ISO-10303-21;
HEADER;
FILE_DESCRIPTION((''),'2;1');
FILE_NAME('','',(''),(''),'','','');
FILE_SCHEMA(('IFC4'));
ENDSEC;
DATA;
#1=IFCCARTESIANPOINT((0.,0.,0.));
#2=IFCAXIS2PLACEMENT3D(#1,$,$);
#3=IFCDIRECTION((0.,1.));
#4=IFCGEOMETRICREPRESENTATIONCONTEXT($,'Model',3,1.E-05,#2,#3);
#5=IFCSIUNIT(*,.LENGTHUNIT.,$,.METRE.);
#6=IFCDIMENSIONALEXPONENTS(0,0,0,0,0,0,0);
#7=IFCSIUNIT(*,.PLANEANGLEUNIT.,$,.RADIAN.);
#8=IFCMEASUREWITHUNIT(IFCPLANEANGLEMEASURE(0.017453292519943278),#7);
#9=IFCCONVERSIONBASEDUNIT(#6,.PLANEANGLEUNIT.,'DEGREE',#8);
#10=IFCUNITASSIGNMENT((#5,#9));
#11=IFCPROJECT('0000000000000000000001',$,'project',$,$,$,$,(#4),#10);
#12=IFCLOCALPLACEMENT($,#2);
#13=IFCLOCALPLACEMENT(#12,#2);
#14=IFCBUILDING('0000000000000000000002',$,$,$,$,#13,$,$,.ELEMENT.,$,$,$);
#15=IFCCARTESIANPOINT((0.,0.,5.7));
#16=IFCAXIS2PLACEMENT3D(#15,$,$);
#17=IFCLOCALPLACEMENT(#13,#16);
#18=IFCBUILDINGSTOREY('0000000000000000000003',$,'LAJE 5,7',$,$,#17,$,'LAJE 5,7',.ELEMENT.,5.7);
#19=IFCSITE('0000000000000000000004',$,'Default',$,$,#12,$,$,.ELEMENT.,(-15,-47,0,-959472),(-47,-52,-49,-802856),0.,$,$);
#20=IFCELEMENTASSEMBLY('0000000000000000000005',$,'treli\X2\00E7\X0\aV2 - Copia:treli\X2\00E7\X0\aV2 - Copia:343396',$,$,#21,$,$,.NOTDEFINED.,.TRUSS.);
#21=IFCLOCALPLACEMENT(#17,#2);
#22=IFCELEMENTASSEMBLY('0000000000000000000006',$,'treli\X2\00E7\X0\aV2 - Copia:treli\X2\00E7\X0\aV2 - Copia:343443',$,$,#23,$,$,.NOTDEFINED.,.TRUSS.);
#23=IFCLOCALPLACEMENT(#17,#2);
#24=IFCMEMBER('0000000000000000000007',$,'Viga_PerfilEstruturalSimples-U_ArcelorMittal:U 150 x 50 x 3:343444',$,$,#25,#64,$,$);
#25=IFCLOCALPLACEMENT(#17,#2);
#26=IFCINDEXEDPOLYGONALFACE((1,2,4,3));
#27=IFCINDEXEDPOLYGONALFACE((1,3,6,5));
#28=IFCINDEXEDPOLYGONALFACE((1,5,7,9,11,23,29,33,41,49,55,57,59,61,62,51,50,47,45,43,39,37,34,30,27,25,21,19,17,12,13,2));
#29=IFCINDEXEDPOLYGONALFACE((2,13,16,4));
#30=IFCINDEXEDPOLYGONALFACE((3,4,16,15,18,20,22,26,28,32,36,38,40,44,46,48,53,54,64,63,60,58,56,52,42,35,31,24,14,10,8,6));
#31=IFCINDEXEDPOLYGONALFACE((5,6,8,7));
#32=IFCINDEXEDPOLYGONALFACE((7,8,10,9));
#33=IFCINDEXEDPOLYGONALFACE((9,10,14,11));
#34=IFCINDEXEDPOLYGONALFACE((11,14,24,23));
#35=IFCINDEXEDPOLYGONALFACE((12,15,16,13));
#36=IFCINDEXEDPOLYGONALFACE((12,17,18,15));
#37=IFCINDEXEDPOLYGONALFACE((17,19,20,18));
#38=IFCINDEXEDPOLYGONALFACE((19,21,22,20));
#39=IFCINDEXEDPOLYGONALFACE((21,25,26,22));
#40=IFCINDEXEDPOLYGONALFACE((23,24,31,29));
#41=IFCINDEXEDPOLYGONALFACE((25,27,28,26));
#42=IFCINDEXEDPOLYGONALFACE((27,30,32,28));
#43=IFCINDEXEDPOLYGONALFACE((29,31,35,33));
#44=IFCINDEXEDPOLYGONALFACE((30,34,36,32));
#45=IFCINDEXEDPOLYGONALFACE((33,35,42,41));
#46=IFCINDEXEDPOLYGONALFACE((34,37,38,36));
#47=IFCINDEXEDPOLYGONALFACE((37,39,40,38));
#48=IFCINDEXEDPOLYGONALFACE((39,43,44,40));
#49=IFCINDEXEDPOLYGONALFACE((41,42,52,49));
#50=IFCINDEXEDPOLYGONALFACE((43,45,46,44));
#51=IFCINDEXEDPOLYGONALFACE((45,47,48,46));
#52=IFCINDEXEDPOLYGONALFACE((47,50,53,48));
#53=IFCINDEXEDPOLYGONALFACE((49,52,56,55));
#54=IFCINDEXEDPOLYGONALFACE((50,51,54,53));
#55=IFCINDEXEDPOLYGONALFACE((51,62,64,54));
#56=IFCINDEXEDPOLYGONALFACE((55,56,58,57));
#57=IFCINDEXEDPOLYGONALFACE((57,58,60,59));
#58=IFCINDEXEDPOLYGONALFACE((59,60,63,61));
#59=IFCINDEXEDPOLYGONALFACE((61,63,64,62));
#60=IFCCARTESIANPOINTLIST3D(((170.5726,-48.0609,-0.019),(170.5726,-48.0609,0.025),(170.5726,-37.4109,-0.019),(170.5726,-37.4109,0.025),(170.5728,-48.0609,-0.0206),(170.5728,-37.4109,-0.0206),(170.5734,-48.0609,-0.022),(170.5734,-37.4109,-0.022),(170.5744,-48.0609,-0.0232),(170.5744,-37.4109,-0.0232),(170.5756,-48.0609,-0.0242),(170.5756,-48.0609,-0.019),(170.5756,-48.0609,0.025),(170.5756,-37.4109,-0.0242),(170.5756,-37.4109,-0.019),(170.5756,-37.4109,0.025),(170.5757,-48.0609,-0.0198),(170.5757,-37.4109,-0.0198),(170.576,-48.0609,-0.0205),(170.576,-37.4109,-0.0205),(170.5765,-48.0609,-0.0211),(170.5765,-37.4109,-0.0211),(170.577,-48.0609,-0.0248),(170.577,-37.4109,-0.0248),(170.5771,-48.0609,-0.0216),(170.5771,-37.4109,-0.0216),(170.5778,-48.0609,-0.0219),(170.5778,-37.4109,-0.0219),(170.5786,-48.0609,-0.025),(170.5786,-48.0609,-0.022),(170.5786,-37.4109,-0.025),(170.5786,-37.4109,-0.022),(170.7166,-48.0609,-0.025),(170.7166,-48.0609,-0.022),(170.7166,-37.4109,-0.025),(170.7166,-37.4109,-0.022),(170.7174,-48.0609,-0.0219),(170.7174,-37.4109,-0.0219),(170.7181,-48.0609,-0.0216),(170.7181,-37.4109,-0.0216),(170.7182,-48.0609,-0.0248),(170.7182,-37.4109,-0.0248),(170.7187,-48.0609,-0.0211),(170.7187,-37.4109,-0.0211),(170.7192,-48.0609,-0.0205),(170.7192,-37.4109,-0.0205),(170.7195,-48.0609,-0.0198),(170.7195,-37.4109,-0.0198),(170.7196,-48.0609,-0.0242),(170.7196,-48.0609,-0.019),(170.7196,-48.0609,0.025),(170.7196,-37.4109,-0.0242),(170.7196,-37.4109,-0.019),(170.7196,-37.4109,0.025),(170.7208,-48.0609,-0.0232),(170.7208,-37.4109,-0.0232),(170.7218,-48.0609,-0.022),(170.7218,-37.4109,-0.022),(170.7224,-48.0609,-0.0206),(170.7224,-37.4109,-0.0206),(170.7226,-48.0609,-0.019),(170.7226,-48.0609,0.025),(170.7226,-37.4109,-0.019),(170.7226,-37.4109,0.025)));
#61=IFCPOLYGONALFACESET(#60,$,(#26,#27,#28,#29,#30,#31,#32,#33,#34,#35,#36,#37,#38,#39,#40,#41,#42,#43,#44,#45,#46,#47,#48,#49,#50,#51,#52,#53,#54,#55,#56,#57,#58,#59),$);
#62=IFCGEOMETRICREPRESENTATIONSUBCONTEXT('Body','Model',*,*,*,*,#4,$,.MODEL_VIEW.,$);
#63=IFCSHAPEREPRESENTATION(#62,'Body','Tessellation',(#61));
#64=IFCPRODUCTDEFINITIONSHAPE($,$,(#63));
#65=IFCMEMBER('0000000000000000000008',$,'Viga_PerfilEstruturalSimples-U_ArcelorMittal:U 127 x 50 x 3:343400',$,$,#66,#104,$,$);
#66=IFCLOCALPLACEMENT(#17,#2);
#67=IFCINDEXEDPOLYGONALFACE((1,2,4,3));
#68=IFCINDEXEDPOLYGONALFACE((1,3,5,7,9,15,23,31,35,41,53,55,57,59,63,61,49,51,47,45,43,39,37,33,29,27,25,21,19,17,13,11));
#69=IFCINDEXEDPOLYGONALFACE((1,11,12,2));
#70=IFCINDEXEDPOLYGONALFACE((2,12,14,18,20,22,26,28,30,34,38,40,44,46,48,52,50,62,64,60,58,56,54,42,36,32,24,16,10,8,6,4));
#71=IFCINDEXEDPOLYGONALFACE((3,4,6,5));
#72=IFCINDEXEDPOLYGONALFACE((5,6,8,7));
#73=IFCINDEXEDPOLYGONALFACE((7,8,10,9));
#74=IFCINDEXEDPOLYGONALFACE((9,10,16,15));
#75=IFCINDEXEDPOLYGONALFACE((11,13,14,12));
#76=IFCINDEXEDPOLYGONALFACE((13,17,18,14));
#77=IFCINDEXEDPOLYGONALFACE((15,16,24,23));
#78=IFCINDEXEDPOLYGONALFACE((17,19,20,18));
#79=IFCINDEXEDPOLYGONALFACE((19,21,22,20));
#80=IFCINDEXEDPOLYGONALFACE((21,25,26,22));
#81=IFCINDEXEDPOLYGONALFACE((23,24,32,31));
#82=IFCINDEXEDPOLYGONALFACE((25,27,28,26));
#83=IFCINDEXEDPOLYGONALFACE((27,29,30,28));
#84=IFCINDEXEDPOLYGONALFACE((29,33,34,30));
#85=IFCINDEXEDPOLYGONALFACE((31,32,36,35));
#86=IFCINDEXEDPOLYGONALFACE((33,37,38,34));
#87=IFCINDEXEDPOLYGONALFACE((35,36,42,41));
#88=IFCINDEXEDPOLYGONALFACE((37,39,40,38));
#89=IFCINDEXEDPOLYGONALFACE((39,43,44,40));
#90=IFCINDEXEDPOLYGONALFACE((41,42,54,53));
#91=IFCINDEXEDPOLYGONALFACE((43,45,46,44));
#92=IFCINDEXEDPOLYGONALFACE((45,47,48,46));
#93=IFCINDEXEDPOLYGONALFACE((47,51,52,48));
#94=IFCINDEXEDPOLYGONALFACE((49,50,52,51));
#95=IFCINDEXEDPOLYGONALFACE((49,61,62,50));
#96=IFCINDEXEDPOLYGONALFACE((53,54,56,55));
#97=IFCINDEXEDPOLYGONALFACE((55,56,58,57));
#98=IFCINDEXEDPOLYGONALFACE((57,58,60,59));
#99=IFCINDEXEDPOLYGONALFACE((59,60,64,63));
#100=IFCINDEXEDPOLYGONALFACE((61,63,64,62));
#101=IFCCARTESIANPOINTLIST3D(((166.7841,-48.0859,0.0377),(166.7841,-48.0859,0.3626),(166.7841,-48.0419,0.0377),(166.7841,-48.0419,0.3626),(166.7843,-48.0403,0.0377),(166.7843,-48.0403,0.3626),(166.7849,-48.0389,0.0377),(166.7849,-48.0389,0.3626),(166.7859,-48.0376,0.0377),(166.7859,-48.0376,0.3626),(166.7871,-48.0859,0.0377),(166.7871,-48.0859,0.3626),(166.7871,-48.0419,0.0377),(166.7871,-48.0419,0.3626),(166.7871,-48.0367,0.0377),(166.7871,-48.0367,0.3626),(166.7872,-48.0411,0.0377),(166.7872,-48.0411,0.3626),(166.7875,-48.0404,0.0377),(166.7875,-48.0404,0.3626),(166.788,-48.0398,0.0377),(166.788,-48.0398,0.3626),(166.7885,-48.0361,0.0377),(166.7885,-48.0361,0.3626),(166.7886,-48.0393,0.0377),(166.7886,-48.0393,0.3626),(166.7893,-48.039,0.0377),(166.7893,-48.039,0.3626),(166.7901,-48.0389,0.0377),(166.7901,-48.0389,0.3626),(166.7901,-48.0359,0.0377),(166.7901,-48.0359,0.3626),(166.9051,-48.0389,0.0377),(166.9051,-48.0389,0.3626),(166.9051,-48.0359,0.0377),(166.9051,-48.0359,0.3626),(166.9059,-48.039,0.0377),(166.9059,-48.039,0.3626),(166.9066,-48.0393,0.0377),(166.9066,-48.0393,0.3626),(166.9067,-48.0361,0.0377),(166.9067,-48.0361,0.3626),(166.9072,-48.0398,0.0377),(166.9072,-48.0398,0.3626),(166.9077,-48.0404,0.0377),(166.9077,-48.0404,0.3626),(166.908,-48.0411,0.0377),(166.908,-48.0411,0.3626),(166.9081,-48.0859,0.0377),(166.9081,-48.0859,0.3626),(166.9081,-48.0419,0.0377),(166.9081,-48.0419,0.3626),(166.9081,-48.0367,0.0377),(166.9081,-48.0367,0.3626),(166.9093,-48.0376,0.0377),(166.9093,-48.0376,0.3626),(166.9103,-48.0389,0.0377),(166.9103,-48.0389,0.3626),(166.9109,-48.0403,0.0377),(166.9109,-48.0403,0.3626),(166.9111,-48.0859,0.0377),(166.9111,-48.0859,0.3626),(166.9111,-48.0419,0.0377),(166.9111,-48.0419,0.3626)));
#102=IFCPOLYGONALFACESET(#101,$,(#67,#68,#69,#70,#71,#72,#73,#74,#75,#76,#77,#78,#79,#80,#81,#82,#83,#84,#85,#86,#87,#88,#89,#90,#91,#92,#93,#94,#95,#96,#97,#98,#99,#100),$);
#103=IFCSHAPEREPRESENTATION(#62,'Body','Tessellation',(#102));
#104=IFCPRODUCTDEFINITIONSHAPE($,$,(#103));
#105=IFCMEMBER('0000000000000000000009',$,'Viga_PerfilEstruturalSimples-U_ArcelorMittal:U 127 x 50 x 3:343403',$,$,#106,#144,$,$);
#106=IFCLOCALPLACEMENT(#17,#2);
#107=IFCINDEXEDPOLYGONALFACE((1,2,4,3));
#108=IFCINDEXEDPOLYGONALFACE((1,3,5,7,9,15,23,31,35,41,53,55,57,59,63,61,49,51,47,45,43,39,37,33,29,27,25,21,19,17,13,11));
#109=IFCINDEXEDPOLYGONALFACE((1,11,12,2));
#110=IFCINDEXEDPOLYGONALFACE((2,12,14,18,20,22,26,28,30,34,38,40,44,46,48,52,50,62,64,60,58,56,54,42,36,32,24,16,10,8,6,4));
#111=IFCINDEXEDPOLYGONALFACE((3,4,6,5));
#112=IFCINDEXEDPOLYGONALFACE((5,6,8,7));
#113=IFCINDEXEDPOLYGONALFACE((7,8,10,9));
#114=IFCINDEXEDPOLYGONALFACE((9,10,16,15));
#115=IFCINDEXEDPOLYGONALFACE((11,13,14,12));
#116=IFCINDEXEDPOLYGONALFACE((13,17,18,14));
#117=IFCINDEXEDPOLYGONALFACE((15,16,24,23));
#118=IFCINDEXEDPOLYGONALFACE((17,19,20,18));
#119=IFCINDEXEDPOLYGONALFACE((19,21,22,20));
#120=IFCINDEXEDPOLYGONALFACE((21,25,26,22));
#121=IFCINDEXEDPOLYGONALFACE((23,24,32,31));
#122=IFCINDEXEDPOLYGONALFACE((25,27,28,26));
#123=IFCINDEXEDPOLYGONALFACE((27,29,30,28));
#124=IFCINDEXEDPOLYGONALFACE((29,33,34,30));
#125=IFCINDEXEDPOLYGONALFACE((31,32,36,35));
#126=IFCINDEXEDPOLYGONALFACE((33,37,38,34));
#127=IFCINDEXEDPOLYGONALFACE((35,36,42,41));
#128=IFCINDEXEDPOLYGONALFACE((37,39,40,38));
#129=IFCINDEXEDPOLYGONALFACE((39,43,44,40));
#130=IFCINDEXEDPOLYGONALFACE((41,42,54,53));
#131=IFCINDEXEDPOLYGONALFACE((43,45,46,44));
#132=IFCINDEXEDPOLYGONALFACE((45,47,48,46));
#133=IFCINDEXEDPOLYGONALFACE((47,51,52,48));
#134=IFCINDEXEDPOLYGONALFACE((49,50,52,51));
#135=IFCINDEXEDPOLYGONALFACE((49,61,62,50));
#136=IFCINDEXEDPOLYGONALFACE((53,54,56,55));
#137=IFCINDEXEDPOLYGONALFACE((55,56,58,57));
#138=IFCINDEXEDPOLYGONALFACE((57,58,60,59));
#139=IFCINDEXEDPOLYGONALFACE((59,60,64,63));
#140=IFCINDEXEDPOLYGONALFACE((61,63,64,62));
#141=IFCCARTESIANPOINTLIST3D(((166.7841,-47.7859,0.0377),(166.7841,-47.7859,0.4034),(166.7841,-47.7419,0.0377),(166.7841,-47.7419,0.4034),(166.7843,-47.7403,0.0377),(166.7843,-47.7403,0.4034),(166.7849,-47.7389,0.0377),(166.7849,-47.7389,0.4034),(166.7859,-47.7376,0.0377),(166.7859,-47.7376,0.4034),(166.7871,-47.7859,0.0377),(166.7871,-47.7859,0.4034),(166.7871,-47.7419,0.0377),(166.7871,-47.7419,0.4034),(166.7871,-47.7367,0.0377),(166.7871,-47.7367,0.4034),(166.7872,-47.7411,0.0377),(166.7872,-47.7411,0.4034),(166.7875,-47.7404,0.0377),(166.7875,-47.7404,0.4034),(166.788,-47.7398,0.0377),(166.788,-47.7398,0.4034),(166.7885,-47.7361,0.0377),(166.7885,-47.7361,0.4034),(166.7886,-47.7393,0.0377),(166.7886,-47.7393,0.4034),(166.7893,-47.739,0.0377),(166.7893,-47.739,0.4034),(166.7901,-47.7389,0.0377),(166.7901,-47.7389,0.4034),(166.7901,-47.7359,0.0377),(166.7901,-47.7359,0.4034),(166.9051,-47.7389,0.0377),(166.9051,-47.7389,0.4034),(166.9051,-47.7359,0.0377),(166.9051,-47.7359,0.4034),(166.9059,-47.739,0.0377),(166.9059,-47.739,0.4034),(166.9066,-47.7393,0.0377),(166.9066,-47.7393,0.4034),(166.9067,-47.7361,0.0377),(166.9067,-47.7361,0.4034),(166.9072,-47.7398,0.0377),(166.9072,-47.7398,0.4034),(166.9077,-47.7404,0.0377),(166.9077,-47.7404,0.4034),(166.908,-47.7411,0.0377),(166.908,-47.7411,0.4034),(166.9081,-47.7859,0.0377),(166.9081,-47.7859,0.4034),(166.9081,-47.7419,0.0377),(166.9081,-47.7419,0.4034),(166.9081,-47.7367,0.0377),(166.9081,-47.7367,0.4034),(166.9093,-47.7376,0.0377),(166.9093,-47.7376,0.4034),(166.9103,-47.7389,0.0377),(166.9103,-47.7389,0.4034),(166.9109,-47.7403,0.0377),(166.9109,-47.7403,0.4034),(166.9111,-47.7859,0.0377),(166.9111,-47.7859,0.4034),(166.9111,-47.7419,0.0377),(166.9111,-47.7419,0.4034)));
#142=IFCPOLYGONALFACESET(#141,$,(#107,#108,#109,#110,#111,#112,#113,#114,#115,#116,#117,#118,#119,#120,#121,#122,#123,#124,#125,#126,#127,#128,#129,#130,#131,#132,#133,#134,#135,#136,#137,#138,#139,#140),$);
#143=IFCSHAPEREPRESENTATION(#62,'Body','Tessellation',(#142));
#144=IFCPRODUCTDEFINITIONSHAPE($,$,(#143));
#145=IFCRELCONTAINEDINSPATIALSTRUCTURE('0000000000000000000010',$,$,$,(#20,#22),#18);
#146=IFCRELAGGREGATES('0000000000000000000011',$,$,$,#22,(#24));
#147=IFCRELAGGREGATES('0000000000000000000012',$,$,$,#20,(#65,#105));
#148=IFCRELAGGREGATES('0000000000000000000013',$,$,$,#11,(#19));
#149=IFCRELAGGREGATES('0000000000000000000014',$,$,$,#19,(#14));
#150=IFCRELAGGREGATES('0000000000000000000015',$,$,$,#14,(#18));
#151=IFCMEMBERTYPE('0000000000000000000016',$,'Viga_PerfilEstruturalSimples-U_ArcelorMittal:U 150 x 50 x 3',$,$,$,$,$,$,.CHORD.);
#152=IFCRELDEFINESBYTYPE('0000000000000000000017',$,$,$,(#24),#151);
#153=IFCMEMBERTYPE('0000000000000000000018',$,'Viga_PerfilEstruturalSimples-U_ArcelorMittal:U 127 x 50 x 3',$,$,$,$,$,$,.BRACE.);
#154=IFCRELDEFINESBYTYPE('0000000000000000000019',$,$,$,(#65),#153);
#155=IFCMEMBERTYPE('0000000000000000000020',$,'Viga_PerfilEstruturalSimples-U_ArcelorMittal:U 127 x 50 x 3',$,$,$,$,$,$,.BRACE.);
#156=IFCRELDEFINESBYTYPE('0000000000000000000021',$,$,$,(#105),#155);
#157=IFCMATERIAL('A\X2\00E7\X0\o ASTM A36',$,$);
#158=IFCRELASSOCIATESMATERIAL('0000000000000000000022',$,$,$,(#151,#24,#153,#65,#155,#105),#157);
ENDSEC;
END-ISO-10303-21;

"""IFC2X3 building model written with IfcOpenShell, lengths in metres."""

from ifc_helpers import new_model, entity, si_unit, converted_unit, direction, frame, frame_2d, origin, place, context, subcontext, project, spatial, polyline, circle_curve, parameter, trimmed, segment, composite_curve, outline, extrude, source, transform, mapped, material, type_object, type_shapes, element, aggregate, save


model = new_model("IFC2X3")

# Units and contexts
model_context = context("Model", 3, precision=1e-05, world=origin(), true_north=direction((0.0, 1.0)))
body_context = subcontext(model_context, "Body", "Model", "MODEL_VIEW")
ifc_project = project(units=[si_unit("LENGTHUNIT", "METRE"), converted_unit("PLANEANGLEUNIT", "DEGREE", entity("IfcPlaneAngleMeasure", 0.017453292519943278), si_unit("PLANEANGLEUNIT", "RADIAN"), dimensions=[0, 0, 0, 0, 0, 0, 0])], contexts=[model_context])

# Site, building, storey
site_placement = place(None, origin())
site = spatial("IfcSite", under=ifc_project, at=site_placement, Name="Default", CompositionType="ELEMENT", RefLatitude=(-15, -47, 0, -959472), RefLongitude=(-47, -52, -49, -802856), RefElevation=0.0)
building_placement = place(site_placement, origin())
building = spatial("IfcBuilding", under=site, at=building_placement, CompositionType="ELEMENT")
storey_placement = place(building_placement, frame((0.0, 0.0, 5.7)))
storey = spatial("IfcBuildingStorey", under=building, at=storey_placement, Name="LAJE 5,7", LongName="LAJE 5,7", CompositionType="ELEMENT", Elevation=5.7)

# Element assemblies, member
assembly_1_placement = place(storey_placement, origin())
assembly_1 = element("IfcElementAssembly", 1, at=assembly_1_placement, inside=storey, Name="treliçaV2 - Copia:treliçaV2 - Copia:343396", AssemblyPlace="NOTDEFINED", PredefinedType="TRUSS")
ifc_material = material(Name="Aço ASTM A36")
member_type_1 = type_object("IfcMemberType", Name="Viga_PerfilEstruturalSimples-U_ArcelorMittal:U 150 x 50 x 3", PredefinedType="CHORD", material=ifc_material)
shared_shape_1 = source(origin(), body_context, "Body", "SweptSolid", [
    extrude(outline(composite_curve([segment(polyline([(-0.069, -0.0192), (0.069, -0.0192)]), True, "CONTINUOUS"), segment(trimmed(circle_curve(frame_2d((0.069, -0.0132), x_axis=(0.0, 1.0)), 0.006), [parameter(180.0)], [parameter(270.0)], True, "PARAMETER"), True, "CONTINUOUS"), segment(polyline([(0.075, -0.0132), (0.075, 0.0308)]), True, "CONTINUOUS"), segment(polyline([(0.075, 0.0308), (0.072, 0.0308)]), True, "CONTINUOUS"), segment(polyline([(0.072, 0.0308), (0.072, -0.0132)]), True, "CONTINUOUS"), segment(trimmed(circle_curve(frame_2d((0.069, -0.0132), x_axis=(0.0, 1.0)), 0.003), [parameter(180.0)], [parameter(270.0)], True, "PARAMETER"), False, "CONTINUOUS"), segment(polyline([(0.069, -0.0162), (-0.069, -0.0162)]), True, "CONTINUOUS"), segment(trimmed(circle_curve(frame_2d((-0.069, -0.0132), x_axis=(0.0, 1.0)), 0.003), [parameter(90.0)], [parameter(180.0)], True, "PARAMETER"), False, "CONTINUOUS"), segment(polyline([(-0.072, -0.0132), (-0.072, 0.0308)]), True, "CONTINUOUS"), segment(polyline([(-0.072, 0.0308), (-0.075, 0.0308)]), True, "CONTINUOUS"), segment(polyline([(-0.075, 0.0308), (-0.075, -0.0132)]), True, "CONTINUOUS"), segment(trimmed(circle_curve(frame_2d((-0.069, -0.0132), x_axis=(0.0, 1.0)), 0.006), [parameter(90.0)], [parameter(180.0)], True, "PARAMETER"), True, "CONTINUOUS")], self_intersect=False)), frame((-5.325, -0.0058, 0.0), z_axis=(1.0, 0.0, 0.0), x_axis=(0.0, 0.0, -1.0)), (0.0, 0.0, 1.0), 10.65),
])
type_shapes(member_type_1, [shared_shape_1])
assembly_2_placement = place(storey_placement, origin())
assembly_2 = element("IfcElementAssembly", 2, at=assembly_2_placement, inside=storey, Name="treliçaV2 - Copia:treliçaV2 - Copia:343443", AssemblyPlace="NOTDEFINED", PredefinedType="TRUSS")
member_1_placement = place(assembly_2_placement, frame((170.6476, -42.7359, 0.0), z_axis=(1.0, 0.0, 0.0), x_axis=(0.0, 1.0, 0.0)))
member_1 = element("IfcMember", 3, at=member_1_placement, type_object=member_type_1, material=ifc_material, Name="Viga_PerfilEstruturalSimples-U_ArcelorMittal:U 150 x 50 x 3:343444", context=body_context, shape_type="MappedRepresentation", body=[
    mapped(shared_shape_1, transform((0.0, 0.0, 0.0), scale=1.0)),
])

# Members
member_type_2 = type_object("IfcMemberType", Name="Viga_PerfilEstruturalSimples-U_ArcelorMittal:U 127 x 50 x 3", PredefinedType="BRACE", material=ifc_material)
shared_shape_2 = source(origin(), body_context, "Body", "SweptSolid", [
    extrude(outline(composite_curve([segment(polyline([(-0.0575, -0.0192), (0.0575, -0.0192)]), True, "CONTINUOUS"), segment(trimmed(circle_curve(frame_2d((0.0575, -0.0132), x_axis=(0.0, 1.0)), 0.006), [parameter(180.0)], [parameter(270.0)], True, "PARAMETER"), True, "CONTINUOUS"), segment(polyline([(0.0635, -0.0132), (0.0635, 0.0308)]), True, "CONTINUOUS"), segment(polyline([(0.0635, 0.0308), (0.0605, 0.0308)]), True, "CONTINUOUS"), segment(polyline([(0.0605, 0.0308), (0.0605, -0.0132)]), True, "CONTINUOUS"), segment(trimmed(circle_curve(frame_2d((0.0575, -0.0132), x_axis=(0.0, 1.0)), 0.003), [parameter(180.0)], [parameter(270.0)], True, "PARAMETER"), False, "CONTINUOUS"), segment(polyline([(0.0575, -0.0162), (-0.0575, -0.0162)]), True, "CONTINUOUS"), segment(trimmed(circle_curve(frame_2d((-0.0575, -0.0132), x_axis=(0.0, 1.0)), 0.003), [parameter(90.0)], [parameter(180.0)], True, "PARAMETER"), False, "CONTINUOUS"), segment(polyline([(-0.0605, -0.0132), (-0.0605, 0.0308)]), True, "CONTINUOUS"), segment(polyline([(-0.0605, 0.0308), (-0.0635, 0.0308)]), True, "CONTINUOUS"), segment(polyline([(-0.0635, 0.0308), (-0.0635, -0.0132)]), True, "CONTINUOUS"), segment(trimmed(circle_curve(frame_2d((-0.0575, -0.0132), x_axis=(0.0, 1.0)), 0.006), [parameter(90.0)], [parameter(180.0)], True, "PARAMETER"), True, "CONTINUOUS")], self_intersect=False)), frame((-0.1623, -0.0058, 0.0), z_axis=(1.0, 0.0, 0.0), x_axis=(0.0, 0.0, -1.0)), (0.0, 0.0, 1.0), 0.3249),
])
type_shapes(member_type_2, [shared_shape_2])
member_2_placement = place(assembly_1_placement, frame((166.8476, -48.0609, 0.2), z_axis=(1.0, 0.0, 0.0), x_axis=(0.0, 0.0, 1.0)))
member_2 = element("IfcMember", 4, at=member_2_placement, type_object=member_type_2, material=ifc_material, Name="Viga_PerfilEstruturalSimples-U_ArcelorMittal:U 127 x 50 x 3:343400", context=body_context, shape_type="MappedRepresentation", body=[
    mapped(shared_shape_2, transform((0.0, 0.0, 0.0), scale=1.0)),
])
member_type_3 = type_object("IfcMemberType", Name="Viga_PerfilEstruturalSimples-U_ArcelorMittal:U 127 x 50 x 3", PredefinedType="BRACE", material=ifc_material)
shared_shape_3 = source(origin(), body_context, "Body", "SweptSolid", [
    extrude(outline(composite_curve([segment(polyline([(-0.0575, -0.0192), (0.0575, -0.0192)]), True, "CONTINUOUS"), segment(trimmed(circle_curve(frame_2d((0.0575, -0.0132), x_axis=(0.0, 1.0)), 0.006), [parameter(180.0)], [parameter(270.0)], True, "PARAMETER"), True, "CONTINUOUS"), segment(polyline([(0.0635, -0.0132), (0.0635, 0.0308)]), True, "CONTINUOUS"), segment(polyline([(0.0635, 0.0308), (0.0605, 0.0308)]), True, "CONTINUOUS"), segment(polyline([(0.0605, 0.0308), (0.0605, -0.0132)]), True, "CONTINUOUS"), segment(trimmed(circle_curve(frame_2d((0.0575, -0.0132), x_axis=(0.0, 1.0)), 0.003), [parameter(180.0)], [parameter(270.0)], True, "PARAMETER"), False, "CONTINUOUS"), segment(polyline([(0.0575, -0.0162), (-0.0575, -0.0162)]), True, "CONTINUOUS"), segment(trimmed(circle_curve(frame_2d((-0.0575, -0.0132), x_axis=(0.0, 1.0)), 0.003), [parameter(90.0)], [parameter(180.0)], True, "PARAMETER"), False, "CONTINUOUS"), segment(polyline([(-0.0605, -0.0132), (-0.0605, 0.0308)]), True, "CONTINUOUS"), segment(polyline([(-0.0605, 0.0308), (-0.0635, 0.0308)]), True, "CONTINUOUS"), segment(polyline([(-0.0635, 0.0308), (-0.0635, -0.0132)]), True, "CONTINUOUS"), segment(trimmed(circle_curve(frame_2d((-0.0575, -0.0132), x_axis=(0.0, 1.0)), 0.006), [parameter(90.0)], [parameter(180.0)], True, "PARAMETER"), True, "CONTINUOUS")], self_intersect=False)), frame((-0.1849, -0.0058, 0.0), z_axis=(1.0, 0.0, 0.0), x_axis=(0.0, 0.0, -1.0)), (0.0, 0.0, 1.0), 0.3657),
])
type_shapes(member_type_3, [shared_shape_3])
member_3_placement = place(assembly_1_placement, frame((166.8476, -47.7609, 0.2226), z_axis=(1.0, 0.0, 0.0), x_axis=(0.0, 0.0, 1.0)))
member_3 = element("IfcMember", 5, at=member_3_placement, type_object=member_type_3, material=ifc_material, Name="Viga_PerfilEstruturalSimples-U_ArcelorMittal:U 127 x 50 x 3:343403", context=body_context, shape_type="MappedRepresentation", body=[
    mapped(shared_shape_3, transform((0.0, 0.0, 0.0), scale=1.0)),
])
aggregate(assembly_2, [member_1])
aggregate(assembly_1, [member_2, member_3])

save(model, "model.ifc")
